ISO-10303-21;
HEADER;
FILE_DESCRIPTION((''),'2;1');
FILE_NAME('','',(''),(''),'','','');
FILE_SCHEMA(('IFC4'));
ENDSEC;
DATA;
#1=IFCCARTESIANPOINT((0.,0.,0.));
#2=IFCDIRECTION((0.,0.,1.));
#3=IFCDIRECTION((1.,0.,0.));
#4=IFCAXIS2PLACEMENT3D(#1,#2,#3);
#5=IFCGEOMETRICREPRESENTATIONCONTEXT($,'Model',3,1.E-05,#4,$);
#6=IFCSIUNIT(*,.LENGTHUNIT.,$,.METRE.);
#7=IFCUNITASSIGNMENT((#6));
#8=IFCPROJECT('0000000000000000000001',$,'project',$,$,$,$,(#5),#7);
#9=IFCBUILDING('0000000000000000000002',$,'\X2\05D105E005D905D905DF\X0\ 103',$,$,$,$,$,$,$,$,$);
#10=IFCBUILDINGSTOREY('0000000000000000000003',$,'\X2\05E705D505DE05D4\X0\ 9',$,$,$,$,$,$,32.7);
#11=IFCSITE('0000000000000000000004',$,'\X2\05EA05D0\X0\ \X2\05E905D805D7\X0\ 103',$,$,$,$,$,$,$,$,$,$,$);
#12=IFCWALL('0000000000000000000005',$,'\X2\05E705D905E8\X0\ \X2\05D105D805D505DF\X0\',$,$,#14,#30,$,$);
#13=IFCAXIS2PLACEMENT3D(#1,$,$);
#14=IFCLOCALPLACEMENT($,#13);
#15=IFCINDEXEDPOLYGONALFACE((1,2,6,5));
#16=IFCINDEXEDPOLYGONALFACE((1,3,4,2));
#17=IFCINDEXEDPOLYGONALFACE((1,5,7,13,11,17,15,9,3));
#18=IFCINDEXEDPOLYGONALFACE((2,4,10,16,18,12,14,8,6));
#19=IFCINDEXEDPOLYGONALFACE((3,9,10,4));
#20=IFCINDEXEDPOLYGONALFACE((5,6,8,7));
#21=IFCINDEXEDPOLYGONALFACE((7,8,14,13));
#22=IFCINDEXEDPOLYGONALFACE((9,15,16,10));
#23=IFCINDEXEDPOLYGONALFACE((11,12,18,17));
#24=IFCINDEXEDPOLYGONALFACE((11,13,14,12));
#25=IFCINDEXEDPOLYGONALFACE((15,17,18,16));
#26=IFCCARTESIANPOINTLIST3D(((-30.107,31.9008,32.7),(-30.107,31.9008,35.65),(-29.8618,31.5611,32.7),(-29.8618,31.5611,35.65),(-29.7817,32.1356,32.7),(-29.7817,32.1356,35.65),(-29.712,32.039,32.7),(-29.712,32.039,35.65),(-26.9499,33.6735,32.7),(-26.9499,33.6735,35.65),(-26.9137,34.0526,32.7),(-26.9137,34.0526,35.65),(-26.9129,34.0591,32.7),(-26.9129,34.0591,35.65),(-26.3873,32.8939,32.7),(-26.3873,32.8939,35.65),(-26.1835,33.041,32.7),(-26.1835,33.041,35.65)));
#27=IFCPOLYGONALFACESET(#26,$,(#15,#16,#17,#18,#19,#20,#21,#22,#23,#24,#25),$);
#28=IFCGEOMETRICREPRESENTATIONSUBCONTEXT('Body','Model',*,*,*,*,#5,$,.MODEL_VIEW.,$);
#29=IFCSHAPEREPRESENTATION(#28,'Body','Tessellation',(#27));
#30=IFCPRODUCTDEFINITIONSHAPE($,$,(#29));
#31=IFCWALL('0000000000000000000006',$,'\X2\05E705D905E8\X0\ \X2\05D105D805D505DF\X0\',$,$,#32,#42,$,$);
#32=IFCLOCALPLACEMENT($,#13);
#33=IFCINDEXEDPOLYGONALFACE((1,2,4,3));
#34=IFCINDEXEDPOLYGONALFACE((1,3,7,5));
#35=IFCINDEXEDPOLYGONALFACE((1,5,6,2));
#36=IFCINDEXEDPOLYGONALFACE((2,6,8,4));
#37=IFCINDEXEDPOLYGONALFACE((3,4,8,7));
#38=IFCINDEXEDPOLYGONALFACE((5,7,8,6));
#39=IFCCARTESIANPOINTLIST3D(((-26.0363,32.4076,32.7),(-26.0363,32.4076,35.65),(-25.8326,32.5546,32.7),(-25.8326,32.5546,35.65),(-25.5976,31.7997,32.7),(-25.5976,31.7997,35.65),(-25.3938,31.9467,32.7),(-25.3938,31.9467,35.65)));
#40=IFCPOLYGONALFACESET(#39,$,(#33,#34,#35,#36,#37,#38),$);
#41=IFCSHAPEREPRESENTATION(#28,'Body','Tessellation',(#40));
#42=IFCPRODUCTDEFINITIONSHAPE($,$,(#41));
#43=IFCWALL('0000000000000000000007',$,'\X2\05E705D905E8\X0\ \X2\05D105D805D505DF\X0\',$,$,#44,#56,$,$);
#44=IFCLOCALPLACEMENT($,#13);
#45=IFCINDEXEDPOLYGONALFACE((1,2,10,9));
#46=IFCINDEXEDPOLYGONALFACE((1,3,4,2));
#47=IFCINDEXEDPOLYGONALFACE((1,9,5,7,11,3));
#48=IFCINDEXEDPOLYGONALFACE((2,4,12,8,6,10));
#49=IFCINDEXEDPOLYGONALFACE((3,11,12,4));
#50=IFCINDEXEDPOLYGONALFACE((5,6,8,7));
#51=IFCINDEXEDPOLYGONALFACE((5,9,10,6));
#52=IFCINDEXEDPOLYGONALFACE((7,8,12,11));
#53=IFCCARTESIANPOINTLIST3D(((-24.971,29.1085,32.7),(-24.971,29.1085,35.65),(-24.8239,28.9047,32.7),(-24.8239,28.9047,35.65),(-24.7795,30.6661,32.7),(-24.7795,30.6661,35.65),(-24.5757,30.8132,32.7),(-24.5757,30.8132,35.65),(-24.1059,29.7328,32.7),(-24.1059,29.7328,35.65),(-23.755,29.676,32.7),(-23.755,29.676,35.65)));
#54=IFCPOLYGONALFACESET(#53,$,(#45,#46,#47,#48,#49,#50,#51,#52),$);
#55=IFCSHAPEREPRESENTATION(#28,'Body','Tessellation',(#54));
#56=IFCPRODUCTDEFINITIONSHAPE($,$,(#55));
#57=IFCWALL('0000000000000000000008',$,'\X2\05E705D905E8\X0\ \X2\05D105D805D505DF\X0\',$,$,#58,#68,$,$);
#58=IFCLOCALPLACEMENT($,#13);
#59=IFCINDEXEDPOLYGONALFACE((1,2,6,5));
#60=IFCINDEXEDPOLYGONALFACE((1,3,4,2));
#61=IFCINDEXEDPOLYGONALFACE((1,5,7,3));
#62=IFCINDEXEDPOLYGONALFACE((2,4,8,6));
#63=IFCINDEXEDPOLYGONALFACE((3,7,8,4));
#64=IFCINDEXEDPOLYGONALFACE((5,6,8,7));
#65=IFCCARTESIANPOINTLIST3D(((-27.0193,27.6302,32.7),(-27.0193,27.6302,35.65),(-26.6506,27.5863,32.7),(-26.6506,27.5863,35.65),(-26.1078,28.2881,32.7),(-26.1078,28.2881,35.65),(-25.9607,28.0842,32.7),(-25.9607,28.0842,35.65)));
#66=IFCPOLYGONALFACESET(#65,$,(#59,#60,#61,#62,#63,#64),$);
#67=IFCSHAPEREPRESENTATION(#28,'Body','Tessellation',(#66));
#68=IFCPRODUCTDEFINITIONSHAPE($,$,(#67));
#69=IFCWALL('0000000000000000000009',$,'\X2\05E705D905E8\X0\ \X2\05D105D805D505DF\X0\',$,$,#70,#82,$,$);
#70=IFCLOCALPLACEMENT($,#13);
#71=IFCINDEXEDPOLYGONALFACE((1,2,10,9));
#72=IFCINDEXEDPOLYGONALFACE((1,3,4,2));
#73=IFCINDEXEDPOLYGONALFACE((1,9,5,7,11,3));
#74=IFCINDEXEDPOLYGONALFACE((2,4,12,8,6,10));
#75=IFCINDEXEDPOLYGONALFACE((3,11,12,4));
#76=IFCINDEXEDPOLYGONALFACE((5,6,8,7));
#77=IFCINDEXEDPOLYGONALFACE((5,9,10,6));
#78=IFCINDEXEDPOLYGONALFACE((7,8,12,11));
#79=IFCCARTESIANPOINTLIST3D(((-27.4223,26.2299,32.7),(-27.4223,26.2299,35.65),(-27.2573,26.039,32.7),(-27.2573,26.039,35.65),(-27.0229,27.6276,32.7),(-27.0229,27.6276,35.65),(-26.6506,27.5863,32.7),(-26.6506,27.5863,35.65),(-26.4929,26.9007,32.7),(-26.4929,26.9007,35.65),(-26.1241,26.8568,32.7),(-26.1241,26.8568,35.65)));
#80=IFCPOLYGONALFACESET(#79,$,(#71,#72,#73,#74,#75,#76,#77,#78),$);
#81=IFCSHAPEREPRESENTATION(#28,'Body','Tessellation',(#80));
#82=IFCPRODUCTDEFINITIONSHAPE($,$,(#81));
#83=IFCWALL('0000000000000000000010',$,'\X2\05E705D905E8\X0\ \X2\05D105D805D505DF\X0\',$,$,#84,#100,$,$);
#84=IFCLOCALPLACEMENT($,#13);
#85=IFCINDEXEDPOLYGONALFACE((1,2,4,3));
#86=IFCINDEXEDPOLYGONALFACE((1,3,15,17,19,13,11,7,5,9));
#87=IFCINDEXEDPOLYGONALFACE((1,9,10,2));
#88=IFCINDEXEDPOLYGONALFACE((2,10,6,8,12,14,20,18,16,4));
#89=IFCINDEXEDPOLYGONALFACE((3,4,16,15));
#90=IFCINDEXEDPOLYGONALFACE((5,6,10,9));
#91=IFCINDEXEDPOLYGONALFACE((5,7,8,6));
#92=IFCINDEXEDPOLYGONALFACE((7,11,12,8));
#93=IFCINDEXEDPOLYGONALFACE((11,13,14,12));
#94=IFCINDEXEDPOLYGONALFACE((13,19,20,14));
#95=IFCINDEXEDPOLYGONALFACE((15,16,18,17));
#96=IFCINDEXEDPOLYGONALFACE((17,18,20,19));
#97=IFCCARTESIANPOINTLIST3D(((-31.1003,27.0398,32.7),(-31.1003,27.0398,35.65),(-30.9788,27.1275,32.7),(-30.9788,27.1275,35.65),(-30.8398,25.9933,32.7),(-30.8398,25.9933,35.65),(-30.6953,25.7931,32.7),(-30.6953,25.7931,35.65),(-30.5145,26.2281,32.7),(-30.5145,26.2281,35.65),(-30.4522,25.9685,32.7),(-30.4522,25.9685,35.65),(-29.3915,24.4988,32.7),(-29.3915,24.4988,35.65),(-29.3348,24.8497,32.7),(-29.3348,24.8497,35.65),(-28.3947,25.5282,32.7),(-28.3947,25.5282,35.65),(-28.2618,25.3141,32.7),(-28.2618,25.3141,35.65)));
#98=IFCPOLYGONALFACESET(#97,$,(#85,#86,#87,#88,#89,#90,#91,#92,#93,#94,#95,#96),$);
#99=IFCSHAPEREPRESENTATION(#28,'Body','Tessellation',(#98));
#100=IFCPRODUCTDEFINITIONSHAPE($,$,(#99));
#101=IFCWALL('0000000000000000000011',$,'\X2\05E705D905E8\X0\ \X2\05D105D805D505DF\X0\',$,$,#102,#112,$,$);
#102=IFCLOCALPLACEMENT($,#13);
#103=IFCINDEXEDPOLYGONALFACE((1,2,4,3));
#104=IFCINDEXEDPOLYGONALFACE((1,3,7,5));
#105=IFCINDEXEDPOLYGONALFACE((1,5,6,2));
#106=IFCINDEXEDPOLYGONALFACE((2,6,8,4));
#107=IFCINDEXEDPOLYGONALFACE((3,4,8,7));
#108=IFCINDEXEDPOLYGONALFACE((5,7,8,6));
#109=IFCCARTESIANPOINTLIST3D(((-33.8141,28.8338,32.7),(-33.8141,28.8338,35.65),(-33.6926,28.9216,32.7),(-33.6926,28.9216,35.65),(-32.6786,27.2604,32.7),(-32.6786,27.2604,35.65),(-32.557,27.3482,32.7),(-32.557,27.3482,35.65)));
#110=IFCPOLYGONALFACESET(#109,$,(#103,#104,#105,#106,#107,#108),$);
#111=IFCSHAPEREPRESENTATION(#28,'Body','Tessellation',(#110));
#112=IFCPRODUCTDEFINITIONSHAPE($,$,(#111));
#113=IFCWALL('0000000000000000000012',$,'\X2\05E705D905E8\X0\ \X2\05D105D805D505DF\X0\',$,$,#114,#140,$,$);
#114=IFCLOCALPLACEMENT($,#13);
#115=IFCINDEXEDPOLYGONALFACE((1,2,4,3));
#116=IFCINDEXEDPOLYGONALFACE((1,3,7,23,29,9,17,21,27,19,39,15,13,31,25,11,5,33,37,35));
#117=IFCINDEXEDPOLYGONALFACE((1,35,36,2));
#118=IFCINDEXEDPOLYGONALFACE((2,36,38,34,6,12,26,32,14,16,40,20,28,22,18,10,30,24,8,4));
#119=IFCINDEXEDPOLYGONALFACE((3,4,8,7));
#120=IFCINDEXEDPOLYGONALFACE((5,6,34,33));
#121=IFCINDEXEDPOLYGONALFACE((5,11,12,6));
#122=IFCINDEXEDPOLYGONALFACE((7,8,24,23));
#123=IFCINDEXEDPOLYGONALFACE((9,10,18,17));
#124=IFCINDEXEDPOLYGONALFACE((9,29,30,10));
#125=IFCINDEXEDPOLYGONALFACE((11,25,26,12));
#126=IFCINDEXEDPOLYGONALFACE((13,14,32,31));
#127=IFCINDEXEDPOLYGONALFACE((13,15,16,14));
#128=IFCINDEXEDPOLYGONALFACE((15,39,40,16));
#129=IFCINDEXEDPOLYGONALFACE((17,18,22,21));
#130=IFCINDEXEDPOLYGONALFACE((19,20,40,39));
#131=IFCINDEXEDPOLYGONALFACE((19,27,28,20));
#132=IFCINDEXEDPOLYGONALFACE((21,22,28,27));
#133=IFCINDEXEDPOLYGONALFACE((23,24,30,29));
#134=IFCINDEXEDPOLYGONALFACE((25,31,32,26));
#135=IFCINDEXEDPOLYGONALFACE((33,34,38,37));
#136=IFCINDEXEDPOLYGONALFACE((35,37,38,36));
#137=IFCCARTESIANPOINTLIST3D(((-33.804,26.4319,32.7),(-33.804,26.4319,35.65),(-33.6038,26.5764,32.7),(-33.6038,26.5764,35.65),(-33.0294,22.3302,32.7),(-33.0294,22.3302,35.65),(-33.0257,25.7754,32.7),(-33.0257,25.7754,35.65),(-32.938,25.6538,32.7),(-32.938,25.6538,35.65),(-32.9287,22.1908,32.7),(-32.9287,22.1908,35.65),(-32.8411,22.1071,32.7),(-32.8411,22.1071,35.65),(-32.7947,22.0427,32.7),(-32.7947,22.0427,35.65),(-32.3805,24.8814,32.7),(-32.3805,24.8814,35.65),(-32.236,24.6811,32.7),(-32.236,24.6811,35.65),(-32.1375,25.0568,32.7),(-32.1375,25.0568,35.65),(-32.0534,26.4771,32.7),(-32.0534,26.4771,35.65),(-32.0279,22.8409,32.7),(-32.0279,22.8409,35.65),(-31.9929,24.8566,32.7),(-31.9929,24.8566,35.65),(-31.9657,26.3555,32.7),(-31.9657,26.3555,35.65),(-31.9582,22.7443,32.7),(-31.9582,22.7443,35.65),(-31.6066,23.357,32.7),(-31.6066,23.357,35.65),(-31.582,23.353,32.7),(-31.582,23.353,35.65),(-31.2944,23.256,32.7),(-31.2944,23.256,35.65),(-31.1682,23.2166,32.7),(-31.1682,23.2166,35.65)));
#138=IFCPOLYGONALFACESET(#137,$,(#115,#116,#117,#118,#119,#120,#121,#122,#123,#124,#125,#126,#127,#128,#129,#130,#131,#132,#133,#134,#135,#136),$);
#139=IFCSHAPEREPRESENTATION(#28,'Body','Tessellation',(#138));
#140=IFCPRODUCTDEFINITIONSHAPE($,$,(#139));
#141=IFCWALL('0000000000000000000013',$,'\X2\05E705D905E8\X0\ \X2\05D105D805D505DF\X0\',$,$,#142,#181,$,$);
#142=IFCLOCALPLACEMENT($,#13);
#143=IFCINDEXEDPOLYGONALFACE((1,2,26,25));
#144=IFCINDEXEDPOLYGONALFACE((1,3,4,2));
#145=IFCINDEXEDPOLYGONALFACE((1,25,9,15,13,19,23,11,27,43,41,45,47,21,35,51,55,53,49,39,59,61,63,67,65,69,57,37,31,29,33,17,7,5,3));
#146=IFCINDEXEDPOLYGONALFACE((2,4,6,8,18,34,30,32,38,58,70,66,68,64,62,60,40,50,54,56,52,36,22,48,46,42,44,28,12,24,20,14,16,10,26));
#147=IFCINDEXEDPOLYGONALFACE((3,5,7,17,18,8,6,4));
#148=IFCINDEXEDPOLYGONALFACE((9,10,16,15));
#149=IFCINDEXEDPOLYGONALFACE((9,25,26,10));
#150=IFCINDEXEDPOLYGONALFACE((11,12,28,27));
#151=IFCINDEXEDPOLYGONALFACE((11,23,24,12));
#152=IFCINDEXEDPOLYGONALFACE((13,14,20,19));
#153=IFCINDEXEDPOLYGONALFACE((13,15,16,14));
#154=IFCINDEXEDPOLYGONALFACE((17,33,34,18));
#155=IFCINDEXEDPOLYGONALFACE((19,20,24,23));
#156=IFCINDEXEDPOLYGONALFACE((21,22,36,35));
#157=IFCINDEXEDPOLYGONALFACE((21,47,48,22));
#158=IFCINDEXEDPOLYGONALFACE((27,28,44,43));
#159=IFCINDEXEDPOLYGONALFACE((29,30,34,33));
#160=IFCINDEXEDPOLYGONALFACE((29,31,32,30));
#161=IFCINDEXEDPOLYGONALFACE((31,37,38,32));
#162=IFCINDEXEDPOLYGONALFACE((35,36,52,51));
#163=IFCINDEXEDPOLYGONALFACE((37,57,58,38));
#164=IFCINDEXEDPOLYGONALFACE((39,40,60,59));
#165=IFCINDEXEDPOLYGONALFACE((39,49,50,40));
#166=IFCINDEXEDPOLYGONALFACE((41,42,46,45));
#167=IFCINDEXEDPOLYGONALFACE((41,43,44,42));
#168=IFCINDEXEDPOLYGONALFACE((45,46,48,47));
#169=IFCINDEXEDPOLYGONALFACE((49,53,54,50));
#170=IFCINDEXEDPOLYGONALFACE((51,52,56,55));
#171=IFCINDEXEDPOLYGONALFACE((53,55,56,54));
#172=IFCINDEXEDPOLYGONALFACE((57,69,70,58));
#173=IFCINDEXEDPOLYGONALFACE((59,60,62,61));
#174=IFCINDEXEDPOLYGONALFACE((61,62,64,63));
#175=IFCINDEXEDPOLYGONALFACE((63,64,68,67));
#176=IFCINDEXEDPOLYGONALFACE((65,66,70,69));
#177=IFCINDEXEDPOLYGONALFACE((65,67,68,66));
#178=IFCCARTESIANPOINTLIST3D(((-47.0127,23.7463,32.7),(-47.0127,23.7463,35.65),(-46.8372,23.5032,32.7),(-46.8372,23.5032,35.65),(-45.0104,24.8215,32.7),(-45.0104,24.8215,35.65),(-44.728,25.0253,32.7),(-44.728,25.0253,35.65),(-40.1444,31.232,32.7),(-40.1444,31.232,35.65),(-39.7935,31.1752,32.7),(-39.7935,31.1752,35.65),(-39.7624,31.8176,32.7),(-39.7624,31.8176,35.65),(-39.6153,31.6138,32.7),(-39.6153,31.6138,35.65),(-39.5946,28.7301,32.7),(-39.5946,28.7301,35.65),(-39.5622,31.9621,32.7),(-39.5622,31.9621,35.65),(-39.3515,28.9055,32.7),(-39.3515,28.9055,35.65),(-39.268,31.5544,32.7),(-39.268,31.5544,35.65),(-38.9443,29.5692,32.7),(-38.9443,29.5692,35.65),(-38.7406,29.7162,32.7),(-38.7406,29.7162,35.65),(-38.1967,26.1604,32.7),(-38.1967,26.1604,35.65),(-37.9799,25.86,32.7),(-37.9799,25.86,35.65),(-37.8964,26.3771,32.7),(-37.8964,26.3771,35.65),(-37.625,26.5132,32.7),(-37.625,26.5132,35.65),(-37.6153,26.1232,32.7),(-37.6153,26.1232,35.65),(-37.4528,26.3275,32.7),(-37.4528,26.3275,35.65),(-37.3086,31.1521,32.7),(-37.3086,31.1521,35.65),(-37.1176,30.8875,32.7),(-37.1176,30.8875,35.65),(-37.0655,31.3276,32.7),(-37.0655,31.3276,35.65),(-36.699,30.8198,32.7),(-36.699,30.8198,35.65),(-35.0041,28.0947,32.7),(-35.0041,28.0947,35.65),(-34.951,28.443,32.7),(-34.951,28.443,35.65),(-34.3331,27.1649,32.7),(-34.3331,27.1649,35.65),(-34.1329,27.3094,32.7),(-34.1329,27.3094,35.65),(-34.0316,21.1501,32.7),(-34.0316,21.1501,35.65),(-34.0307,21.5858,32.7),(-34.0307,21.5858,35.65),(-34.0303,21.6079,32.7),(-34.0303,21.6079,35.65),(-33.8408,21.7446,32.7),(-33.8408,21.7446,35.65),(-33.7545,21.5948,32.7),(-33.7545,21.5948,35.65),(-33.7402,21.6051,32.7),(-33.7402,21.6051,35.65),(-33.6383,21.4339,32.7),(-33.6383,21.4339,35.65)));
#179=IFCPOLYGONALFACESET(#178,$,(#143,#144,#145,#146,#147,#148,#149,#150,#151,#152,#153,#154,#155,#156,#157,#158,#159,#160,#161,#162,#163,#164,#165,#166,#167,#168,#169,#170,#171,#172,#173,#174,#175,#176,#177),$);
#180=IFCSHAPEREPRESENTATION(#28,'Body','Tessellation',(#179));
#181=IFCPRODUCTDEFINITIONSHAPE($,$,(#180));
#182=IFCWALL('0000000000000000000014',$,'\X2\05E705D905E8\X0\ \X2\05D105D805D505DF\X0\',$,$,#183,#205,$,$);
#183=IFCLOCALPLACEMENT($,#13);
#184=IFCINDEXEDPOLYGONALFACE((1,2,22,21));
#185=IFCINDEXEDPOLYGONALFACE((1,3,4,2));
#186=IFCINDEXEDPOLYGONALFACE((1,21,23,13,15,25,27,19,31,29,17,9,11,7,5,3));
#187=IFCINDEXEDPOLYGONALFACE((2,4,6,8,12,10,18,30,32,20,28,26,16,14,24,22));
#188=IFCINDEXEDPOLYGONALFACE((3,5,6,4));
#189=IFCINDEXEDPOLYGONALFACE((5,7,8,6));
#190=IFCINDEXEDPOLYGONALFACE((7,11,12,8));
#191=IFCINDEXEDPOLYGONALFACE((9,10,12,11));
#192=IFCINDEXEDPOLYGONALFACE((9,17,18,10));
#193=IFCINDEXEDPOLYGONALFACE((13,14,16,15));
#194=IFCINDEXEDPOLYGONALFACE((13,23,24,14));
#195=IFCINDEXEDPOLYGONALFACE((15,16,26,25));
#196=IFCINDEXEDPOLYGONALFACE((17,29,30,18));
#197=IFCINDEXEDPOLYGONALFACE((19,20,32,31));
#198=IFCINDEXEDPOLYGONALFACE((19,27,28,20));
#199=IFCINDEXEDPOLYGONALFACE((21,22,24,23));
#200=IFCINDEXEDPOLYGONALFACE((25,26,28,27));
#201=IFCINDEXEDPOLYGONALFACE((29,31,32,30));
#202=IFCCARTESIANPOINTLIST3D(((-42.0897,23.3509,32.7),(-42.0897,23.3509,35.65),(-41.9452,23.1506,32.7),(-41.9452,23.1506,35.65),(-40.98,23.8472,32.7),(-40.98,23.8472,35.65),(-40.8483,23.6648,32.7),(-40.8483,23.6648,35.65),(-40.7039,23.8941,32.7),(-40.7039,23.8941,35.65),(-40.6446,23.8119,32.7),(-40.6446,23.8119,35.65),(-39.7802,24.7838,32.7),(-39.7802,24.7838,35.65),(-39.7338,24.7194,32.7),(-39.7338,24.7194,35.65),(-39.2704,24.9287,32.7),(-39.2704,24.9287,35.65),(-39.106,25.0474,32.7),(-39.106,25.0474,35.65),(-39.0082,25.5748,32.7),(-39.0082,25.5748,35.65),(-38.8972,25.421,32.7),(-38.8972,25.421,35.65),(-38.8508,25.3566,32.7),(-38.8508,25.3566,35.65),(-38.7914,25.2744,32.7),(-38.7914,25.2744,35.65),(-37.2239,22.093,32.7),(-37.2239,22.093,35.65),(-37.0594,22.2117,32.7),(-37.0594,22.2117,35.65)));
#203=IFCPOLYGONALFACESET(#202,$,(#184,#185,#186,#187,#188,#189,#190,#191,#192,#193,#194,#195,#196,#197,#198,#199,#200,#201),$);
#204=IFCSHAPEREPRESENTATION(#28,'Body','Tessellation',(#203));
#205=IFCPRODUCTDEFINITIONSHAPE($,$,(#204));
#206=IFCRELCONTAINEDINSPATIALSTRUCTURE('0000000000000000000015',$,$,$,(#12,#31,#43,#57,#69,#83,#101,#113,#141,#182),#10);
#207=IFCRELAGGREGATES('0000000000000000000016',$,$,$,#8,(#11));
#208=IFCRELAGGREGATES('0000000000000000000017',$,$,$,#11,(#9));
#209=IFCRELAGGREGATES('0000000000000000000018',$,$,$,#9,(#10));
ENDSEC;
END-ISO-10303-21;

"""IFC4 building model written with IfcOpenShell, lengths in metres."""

from ifc_helpers import new_model, si_unit, frame, origin_with_axes, context, subcontext, project, spatial, polyline, outline, extrude, element, save


model = new_model("IFC4")

# Units and contexts
model_context = context("Model", 3, precision=1e-05, world=origin_with_axes())
body_context = subcontext(model_context, "Body", "Model", "MODEL_VIEW")
ifc_project = project(units=[si_unit("LENGTHUNIT", "METRE")], contexts=[model_context])

# Site, building, storey
site = spatial("IfcSite", under=ifc_project, Name="תא שטח 103")
building = spatial("IfcBuilding", under=site, Name="בניין 103")
storey = spatial("IfcBuildingStorey", under=building, Name="קומה 9", Elevation=32.7)

# Walls
element("IfcWall", 1, inside=storey, Name="קיר בטון", context=body_context, shape_type="SweptSolid", body=[
    extrude(outline(polyline([(-26.9499, 33.6735), (-29.8618, 31.5611), (-30.107, 31.9008), (-29.7817, 32.1356), (-29.712, 32.039), (-26.9129, 34.0591), (-26.9203, 33.994), (-26.9139, 34.0529), (-26.1835, 33.041), (-26.3873, 32.8939), (-26.9499, 33.6735)])), frame((0.0, 0.0, 32.7)), (0.0, 0.0, 1.0), 2.95),
])
element("IfcWall", 2, inside=storey, Name="קיר בטון", context=body_context, shape_type="SweptSolid", body=[
    extrude(outline(polyline([(-25.8326, 32.5546), (-25.3938, 31.9467), (-25.5976, 31.7997), (-26.0363, 32.4076), (-25.8326, 32.5546)])), frame((0.0, 0.0, 32.7)), (0.0, 0.0, 1.0), 2.95),
])
element("IfcWall", 3, inside=storey, Name="קיר בטון", context=body_context, shape_type="SweptSolid", body=[
    extrude(outline(polyline([(-24.8239, 28.9047), (-24.971, 29.1085), (-24.1059, 29.7328), (-24.7795, 30.6661), (-24.5757, 30.8132), (-23.755, 29.676), (-24.8239, 28.9047)])), frame((0.0, 0.0, 32.7)), (0.0, 0.0, 1.0), 2.95),
])
element("IfcWall", 4, inside=storey, Name="קיר בטון", context=body_context, shape_type="SweptSolid", body=[
    extrude(outline(polyline([(-26.6506, 27.5863), (-27.0193, 27.6302), (-26.1078, 28.2881), (-25.9607, 28.0842), (-26.6506, 27.5863)])), frame((0.0, 0.0, 32.7)), (0.0, 0.0, 1.0), 2.95),
])
element("IfcWall", 5, inside=storey, Name="קיר בטון", context=body_context, shape_type="SweptSolid", body=[
    extrude(outline(polyline([(-27.2573, 26.039), (-27.4223, 26.2299), (-26.4929, 26.9007), (-27.0229, 27.6276), (-26.6506, 27.5863), (-26.1241, 26.8568), (-27.2573, 26.039)])), frame((0.0, 0.0, 32.7)), (0.0, 0.0, 1.0), 2.95),
])
element("IfcWall", 6, inside=storey, Name="קיר בטון", context=body_context, shape_type="SweptSolid", body=[
    extrude(outline(polyline([(-29.3915, 24.4988), (-30.4522, 25.9685), (-30.6953, 25.7931), (-30.8398, 25.9933), (-30.5145, 26.2281), (-31.1003, 27.0398), (-30.9788, 27.1275), (-29.3348, 24.8497), (-28.3947, 25.5282), (-28.2618, 25.3141), (-29.3915, 24.4988)])), frame((0.0, 0.0, 32.7)), (0.0, 0.0, 1.0), 2.95),
])
element("IfcWall", 7, inside=storey, Name="קיר בטון", context=body_context, shape_type="SweptSolid", body=[
    extrude(outline(polyline([(-32.6786, 27.2604), (-33.8141, 28.8338), (-33.6926, 28.9216), (-32.557, 27.3482), (-32.6786, 27.2604)])), frame((0.0, 0.0, 32.7)), (0.0, 0.0, 1.0), 2.95),
])
element("IfcWall", 8, inside=storey, Name="קיר בטון", context=body_context, shape_type="SweptSolid", body=[
    extrude(outline(polyline([(-32.236, 24.6811), (-31.1682, 23.2166), (-32.7947, 22.0427), (-32.8411, 22.1071), (-31.9582, 22.7443), (-32.0279, 22.8409), (-32.9287, 22.1908), (-33.0294, 22.3302), (-31.6066, 23.357), (-31.2944, 23.256), (-31.582, 23.353), (-33.804, 26.4319), (-33.6038, 26.5764), (-33.0257, 25.7754), (-32.0534, 26.4771), (-31.9657, 26.3555), (-32.938, 25.6538), (-32.3805, 24.8814), (-32.1375, 25.0568), (-31.9929, 24.8566), (-32.236, 24.6811)])), frame((0.0, 0.0, 32.7)), (0.0, 0.0, 1.0), 2.95),
])
element("IfcWall", 9, inside=storey, Name="קיר בטון", context=body_context, shape_type="SweptSolid", body=[
    extrude(outline(polyline([(-37.4528, 26.3275), (-34.0307, 21.5858), (-34.0303, 21.6079), (-33.8408, 21.7446), (-33.7402, 21.6051), (-33.7545, 21.5948), (-33.6383, 21.4339), (-34.0316, 21.1501), (-37.6153, 26.1232), (-37.9799, 25.86), (-38.1967, 26.1604), (-37.8964, 26.3771), (-39.5946, 28.7301), (-44.728, 25.0253), (-45.0104, 24.8215), (-46.8372, 23.5032), (-47.0127, 23.7463), (-38.9443, 29.5692), (-40.1444, 31.232), (-39.6153, 31.6138), (-39.7624, 31.8176), (-39.5622, 31.9621), (-39.268, 31.5544), (-39.7935, 31.1752), (-38.7406, 29.7162), (-37.1176, 30.8875), (-37.3086, 31.1521), (-37.0655, 31.3276), (-36.699, 30.8198), (-39.3515, 28.9055), (-37.625, 26.5132), (-34.951, 28.443), (-34.1329, 27.3094), (-34.3331, 27.1649), (-35.0041, 28.0947), (-37.4528, 26.3275)])), frame((0.0, 0.0, 32.7)), (0.0, 0.0, 1.0), 2.95),
])
element("IfcWall", 10, inside=storey, Name="קיר בטון", context=body_context, shape_type="SweptSolid", body=[
    extrude(outline(polyline([(-37.2239, 22.093), (-39.2704, 24.9287), (-40.7039, 23.8941), (-40.6446, 23.8119), (-40.8483, 23.6648), (-40.98, 23.8472), (-41.9452, 23.1506), (-42.0897, 23.3509), (-39.0082, 25.5748), (-38.8972, 25.421), (-39.7802, 24.7838), (-39.7338, 24.7194), (-38.8508, 25.3566), (-38.7914, 25.2744), (-39.106, 25.0474), (-37.0594, 22.2117), (-37.2239, 22.093)])), frame((0.0, 0.0, 32.7)), (0.0, 0.0, 1.0), 2.95),
])

save(model, "model.ifc")
